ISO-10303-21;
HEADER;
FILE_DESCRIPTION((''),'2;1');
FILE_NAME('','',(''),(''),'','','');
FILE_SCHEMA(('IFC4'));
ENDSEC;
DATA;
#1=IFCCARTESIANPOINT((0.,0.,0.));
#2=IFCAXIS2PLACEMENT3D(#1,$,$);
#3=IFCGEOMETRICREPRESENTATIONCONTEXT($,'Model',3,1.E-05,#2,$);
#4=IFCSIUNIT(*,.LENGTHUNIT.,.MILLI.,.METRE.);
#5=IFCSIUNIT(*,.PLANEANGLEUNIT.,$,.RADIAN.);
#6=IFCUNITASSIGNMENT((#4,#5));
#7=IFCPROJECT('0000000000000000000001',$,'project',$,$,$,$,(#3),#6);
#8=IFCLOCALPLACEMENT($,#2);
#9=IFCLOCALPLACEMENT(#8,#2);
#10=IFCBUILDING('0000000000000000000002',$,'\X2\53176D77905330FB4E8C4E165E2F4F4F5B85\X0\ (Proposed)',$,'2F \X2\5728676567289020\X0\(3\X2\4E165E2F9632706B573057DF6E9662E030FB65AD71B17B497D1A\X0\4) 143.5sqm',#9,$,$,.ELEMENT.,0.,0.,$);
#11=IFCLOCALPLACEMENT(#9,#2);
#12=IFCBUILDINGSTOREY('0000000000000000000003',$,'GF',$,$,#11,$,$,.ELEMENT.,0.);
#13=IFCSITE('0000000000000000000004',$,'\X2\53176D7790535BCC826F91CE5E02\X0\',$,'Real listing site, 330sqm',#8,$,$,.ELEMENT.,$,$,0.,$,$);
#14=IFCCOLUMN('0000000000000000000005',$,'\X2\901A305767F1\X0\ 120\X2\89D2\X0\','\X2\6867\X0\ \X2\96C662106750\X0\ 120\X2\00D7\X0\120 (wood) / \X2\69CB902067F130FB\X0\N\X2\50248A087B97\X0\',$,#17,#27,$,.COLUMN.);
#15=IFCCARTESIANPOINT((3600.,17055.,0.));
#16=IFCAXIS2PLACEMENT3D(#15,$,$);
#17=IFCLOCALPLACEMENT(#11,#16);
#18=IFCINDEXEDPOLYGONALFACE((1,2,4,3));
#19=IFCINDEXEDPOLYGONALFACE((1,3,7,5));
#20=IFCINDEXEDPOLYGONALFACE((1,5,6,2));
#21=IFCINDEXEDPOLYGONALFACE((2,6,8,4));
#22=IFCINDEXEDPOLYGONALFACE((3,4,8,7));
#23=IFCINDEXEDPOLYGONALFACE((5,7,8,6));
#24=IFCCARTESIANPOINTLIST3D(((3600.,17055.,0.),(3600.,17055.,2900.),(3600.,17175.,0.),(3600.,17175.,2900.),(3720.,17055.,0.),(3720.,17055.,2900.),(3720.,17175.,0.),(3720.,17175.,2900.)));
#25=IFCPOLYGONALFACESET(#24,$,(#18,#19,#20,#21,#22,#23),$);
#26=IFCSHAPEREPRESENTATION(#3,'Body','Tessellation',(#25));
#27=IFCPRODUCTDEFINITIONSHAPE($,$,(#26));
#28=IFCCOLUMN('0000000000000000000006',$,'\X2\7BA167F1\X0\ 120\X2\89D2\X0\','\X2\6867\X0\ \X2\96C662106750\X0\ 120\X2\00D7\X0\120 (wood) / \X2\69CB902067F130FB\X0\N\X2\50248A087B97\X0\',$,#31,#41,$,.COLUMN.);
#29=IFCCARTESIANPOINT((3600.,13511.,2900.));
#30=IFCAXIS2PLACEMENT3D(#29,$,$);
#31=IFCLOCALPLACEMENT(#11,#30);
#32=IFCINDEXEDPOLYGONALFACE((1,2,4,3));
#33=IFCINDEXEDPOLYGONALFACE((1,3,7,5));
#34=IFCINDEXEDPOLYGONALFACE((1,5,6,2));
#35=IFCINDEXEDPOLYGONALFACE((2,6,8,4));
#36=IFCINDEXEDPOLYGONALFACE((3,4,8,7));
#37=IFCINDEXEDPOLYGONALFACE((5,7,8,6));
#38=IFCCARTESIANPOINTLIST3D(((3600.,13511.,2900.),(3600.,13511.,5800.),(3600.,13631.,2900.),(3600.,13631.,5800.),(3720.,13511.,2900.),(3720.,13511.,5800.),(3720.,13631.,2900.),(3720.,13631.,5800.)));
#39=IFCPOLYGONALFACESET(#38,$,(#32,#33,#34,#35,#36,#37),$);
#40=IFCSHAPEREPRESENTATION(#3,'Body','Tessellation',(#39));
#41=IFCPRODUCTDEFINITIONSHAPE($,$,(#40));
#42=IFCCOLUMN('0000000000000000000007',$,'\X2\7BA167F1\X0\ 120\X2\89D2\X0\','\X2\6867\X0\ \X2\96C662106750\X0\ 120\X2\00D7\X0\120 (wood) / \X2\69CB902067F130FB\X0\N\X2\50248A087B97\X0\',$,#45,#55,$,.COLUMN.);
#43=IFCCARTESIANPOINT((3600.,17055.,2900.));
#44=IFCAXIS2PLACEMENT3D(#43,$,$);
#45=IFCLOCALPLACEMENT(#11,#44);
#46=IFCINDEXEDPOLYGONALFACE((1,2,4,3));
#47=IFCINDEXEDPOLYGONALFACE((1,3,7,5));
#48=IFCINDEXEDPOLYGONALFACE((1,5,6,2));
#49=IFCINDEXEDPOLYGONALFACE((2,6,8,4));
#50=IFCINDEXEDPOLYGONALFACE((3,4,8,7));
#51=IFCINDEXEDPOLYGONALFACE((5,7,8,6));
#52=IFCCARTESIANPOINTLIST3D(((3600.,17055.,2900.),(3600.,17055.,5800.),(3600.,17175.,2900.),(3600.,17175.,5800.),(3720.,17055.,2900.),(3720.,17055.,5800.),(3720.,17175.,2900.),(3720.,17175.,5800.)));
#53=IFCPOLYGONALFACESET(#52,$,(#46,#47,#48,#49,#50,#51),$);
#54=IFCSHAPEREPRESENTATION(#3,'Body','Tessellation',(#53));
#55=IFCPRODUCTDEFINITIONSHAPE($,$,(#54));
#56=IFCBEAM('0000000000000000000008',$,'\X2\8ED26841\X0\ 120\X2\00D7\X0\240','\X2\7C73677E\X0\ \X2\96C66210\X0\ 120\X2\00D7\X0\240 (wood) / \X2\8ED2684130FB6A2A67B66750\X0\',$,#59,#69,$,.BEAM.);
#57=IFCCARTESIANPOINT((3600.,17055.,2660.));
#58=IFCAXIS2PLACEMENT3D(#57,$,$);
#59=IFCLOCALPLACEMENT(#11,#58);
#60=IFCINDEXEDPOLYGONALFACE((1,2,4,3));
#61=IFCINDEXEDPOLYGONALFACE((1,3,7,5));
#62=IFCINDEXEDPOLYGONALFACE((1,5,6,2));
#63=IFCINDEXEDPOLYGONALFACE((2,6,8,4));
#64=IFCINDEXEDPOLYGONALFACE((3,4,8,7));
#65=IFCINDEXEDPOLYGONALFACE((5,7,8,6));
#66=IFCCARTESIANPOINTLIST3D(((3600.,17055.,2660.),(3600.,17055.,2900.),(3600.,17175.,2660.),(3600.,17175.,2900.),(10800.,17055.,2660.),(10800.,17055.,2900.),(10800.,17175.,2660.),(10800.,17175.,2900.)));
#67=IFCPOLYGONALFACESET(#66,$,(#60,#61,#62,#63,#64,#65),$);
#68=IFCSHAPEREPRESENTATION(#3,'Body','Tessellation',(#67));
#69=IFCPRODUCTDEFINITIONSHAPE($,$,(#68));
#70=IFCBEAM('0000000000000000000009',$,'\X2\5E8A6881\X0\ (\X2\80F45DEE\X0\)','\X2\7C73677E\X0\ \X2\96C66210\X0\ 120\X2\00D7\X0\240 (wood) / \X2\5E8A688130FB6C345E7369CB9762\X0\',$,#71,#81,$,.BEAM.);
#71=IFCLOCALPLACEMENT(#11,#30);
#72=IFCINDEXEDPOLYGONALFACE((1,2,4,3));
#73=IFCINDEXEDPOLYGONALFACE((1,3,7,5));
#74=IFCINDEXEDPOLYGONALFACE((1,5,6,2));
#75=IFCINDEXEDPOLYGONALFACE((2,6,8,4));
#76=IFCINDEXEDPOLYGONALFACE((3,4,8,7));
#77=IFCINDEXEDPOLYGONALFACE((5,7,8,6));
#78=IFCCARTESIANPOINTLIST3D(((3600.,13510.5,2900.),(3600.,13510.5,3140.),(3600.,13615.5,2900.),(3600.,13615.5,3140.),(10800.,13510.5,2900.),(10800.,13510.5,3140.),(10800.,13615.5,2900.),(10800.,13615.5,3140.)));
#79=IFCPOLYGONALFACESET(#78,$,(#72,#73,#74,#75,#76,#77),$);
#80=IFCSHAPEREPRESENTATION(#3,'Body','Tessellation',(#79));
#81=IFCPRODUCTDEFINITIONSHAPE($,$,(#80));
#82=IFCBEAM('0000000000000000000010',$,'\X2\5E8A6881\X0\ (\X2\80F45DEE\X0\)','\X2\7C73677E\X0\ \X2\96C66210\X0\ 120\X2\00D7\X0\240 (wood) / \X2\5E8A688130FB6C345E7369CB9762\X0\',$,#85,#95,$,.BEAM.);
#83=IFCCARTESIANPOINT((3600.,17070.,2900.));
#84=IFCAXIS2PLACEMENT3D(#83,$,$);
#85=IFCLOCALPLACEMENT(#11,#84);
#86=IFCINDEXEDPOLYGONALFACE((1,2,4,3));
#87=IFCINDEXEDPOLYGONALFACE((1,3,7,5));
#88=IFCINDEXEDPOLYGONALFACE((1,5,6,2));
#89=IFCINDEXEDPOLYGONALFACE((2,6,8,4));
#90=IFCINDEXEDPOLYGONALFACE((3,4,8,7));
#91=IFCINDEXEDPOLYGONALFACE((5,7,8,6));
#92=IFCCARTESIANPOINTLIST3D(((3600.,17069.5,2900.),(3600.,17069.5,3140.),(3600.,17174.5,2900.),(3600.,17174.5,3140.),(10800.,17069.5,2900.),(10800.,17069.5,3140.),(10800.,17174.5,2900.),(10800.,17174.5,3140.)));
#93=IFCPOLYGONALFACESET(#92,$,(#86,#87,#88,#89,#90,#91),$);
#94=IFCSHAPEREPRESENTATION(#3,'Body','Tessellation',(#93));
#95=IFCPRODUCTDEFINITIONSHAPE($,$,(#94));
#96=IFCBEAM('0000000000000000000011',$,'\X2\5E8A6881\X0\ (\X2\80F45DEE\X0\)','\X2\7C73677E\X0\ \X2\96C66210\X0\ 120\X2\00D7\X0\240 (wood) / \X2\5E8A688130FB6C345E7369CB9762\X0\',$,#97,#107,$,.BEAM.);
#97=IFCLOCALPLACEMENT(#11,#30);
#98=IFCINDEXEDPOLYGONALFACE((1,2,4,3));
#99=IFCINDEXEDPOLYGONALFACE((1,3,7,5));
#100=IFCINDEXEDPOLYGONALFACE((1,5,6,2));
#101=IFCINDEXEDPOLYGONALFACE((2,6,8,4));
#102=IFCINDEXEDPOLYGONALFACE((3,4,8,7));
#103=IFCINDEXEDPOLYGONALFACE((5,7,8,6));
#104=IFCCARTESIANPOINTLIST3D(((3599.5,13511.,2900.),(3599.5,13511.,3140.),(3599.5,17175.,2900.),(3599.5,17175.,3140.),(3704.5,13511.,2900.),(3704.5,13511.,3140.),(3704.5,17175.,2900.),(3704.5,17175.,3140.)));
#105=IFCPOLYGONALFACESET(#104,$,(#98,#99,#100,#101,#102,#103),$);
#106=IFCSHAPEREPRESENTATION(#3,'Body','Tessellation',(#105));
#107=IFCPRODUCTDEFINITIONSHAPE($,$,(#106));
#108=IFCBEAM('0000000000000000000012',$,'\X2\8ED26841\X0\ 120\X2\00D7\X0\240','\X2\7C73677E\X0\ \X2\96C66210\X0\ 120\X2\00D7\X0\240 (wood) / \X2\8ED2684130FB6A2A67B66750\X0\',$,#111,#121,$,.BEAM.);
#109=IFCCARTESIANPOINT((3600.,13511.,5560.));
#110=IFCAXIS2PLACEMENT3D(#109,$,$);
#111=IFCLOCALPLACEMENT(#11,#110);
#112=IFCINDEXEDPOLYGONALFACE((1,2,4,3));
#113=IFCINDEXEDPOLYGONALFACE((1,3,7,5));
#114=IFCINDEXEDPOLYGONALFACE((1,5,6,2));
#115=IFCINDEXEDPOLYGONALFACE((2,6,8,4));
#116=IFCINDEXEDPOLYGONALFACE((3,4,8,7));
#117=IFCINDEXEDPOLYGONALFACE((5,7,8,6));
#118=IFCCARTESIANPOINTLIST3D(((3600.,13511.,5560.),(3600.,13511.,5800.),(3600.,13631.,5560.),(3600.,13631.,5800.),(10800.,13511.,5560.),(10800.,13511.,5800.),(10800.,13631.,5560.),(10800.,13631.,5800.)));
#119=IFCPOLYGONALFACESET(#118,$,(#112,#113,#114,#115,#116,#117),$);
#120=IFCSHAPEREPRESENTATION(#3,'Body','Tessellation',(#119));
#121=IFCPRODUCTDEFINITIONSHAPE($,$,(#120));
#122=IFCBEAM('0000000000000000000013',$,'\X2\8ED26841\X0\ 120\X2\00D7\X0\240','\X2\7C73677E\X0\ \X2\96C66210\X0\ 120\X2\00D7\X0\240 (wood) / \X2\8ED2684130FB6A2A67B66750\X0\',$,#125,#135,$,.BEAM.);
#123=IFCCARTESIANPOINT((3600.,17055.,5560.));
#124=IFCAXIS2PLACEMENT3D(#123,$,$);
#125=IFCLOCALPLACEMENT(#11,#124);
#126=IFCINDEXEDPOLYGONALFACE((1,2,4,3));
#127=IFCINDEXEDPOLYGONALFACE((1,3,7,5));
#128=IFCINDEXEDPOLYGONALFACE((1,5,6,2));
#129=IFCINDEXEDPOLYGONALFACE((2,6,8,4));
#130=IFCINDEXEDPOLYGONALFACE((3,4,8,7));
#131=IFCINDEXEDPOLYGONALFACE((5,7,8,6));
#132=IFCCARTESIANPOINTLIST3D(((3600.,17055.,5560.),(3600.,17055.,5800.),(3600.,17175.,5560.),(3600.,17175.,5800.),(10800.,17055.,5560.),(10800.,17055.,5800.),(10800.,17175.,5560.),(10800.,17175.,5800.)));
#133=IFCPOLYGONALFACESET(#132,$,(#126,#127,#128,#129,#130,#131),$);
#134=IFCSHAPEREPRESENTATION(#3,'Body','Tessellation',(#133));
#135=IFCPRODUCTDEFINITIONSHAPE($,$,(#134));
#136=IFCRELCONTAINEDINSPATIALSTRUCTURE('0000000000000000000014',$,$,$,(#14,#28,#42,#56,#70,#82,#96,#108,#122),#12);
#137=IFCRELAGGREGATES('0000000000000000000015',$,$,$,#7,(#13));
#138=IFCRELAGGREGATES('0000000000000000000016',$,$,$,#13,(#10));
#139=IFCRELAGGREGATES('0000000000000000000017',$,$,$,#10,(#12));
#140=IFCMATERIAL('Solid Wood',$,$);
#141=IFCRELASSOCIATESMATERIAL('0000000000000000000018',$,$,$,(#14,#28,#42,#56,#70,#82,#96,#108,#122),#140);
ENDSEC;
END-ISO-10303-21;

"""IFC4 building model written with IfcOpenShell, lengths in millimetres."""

from ifc_helpers import new_model, si_unit, frame, frame_2d, origin, place, context, project, spatial, rectangle, extrude, material, element, save


model = new_model("IFC4")

# Units and contexts
model_context = context("Model", 3, precision=1e-05, world=origin())
ifc_project = project(units=[si_unit("LENGTHUNIT", "METRE", prefix="MILLI"), si_unit("PLANEANGLEUNIT", "RADIAN")], contexts=[model_context])

# Site, building, storey
site_placement = place(None, origin())
site = spatial("IfcSite", under=ifc_project, at=site_placement, Name="北海道富良野市", ObjectType="Real listing site, 330sqm", CompositionType="ELEMENT", RefElevation=0.0)
building_placement = place(site_placement, origin())
building = spatial("IfcBuilding", under=site, at=building_placement, Name="北海道・二世帯住宅 (Proposed)", ObjectType="2F 在来木造(3世帯防火地域準拠・断熱等級4) 143.5sqm", CompositionType="ELEMENT", ElevationOfRefHeight=0.0, ElevationOfTerrain=0.0)
storey_placement = place(building_placement, origin())
storey = spatial("IfcBuildingStorey", under=building, at=storey_placement, Name="GF", CompositionType="ELEMENT", Elevation=0.0)

# Columns
ifc_material_1 = material(Name="Solid Wood")
column_1_placement = place(storey_placement, frame((3600.0, 17055.0, 0.0)))
element("IfcColumn", 1, at=column_1_placement, inside=storey, material=ifc_material_1, Name="通し柱 120角", Description="桧 集成材 120×120 (wood) / 構造柱・N値計算", PredefinedType="COLUMN", context=model_context, shape_type="SweptSolid", body=[
    extrude(rectangle(XDim=120.0, YDim=120.0, at=frame_2d((60.0, 60.0))), frame((3600.0, 17055.0, 0.0)), (0.0, 0.0, 1.0), 2900.0),
])
column_2_placement = place(storey_placement, frame((3600.0, 13511.0, 2900.0)))
element("IfcColumn", 2, at=column_2_placement, inside=storey, material=ifc_material_1, Name="管柱 120角", Description="桧 集成材 120×120 (wood) / 構造柱・N値計算", PredefinedType="COLUMN", context=model_context, shape_type="SweptSolid", body=[
    extrude(rectangle(XDim=120.0, YDim=120.0, at=frame_2d((60.0, 60.0))), frame((3600.0, 13511.0, 2900.0)), (0.0, 0.0, 1.0), 2900.0),
])
column_3_placement = place(storey_placement, frame((3600.0, 17055.0, 2900.0)))
element("IfcColumn", 3, at=column_3_placement, inside=storey, material=ifc_material_1, Name="管柱 120角", Description="桧 集成材 120×120 (wood) / 構造柱・N値計算", PredefinedType="COLUMN", context=model_context, shape_type="SweptSolid", body=[
    extrude(rectangle(XDim=120.0, YDim=120.0, at=frame_2d((60.0, 60.0))), frame((3600.0, 17055.0, 2900.0)), (0.0, 0.0, 1.0), 2900.0),
])

# Beams
beam_1_placement = place(storey_placement, frame((3600.0, 17055.0, 2660.0)))
element("IfcBeam", 4, at=beam_1_placement, inside=storey, material=ifc_material_1, Name="軒桁 120×240", Description="米松 集成 120×240 (wood) / 軒桁・横架材", PredefinedType="BEAM", context=model_context, shape_type="SweptSolid", body=[
    extrude(rectangle(XDim=7200.0, YDim=120.0, at=frame_2d((3600.0, 60.0))), frame((3600.0, 17055.0, 2660.0)), (0.0, 0.0, 1.0), 240.0),
])
beam_2_placement = place(storey_placement, frame((3600.0, 13511.0, 2900.0)))
element("IfcBeam", 5, at=beam_2_placement, inside=storey, material=ifc_material_1, Name="床梁 (胴差)", Description="米松 集成 120×240 (wood) / 床梁・水平構面", PredefinedType="BEAM", context=model_context, shape_type="SweptSolid", body=[
    extrude(rectangle(XDim=7200.0, YDim=105.0, at=frame_2d((3600.0, 52.0))), frame((3600.0, 13511.0, 2900.0)), (0.0, 0.0, 1.0), 240.0),
])
beam_3_placement = place(storey_placement, frame((3600.0, 17070.0, 2900.0)))
element("IfcBeam", 6, at=beam_3_placement, inside=storey, material=ifc_material_1, Name="床梁 (胴差)", Description="米松 集成 120×240 (wood) / 床梁・水平構面", PredefinedType="BEAM", context=model_context, shape_type="SweptSolid", body=[
    extrude(rectangle(XDim=7200.0, YDim=105.0, at=frame_2d((3600.0, 52.0))), frame((3600.0, 17070.0, 2900.0)), (0.0, 0.0, 1.0), 240.0),
])
beam_4_placement = place(storey_placement, frame((3600.0, 13511.0, 2900.0)))
element("IfcBeam", 7, at=beam_4_placement, inside=storey, material=ifc_material_1, Name="床梁 (胴差)", Description="米松 集成 120×240 (wood) / 床梁・水平構面", PredefinedType="BEAM", context=model_context, shape_type="SweptSolid", body=[
    extrude(rectangle(XDim=105.0, YDim=3664.0, at=frame_2d((52.0, 1832.0))), frame((3600.0, 13511.0, 2900.0)), (0.0, 0.0, 1.0), 240.0),
])
beam_5_placement = place(storey_placement, frame((3600.0, 13511.0, 5560.0)))
element("IfcBeam", 8, at=beam_5_placement, inside=storey, material=ifc_material_1, Name="軒桁 120×240", Description="米松 集成 120×240 (wood) / 軒桁・横架材", PredefinedType="BEAM", context=model_context, shape_type="SweptSolid", body=[
    extrude(rectangle(XDim=7200.0, YDim=120.0, at=frame_2d((3600.0, 60.0))), frame((3600.0, 13511.0, 5560.0)), (0.0, 0.0, 1.0), 240.0),
])
beam_6_placement = place(storey_placement, frame((3600.0, 17055.0, 5560.0)))
element("IfcBeam", 9, at=beam_6_placement, inside=storey, material=ifc_material_1, Name="軒桁 120×240", Description="米松 集成 120×240 (wood) / 軒桁・横架材", PredefinedType="BEAM", context=model_context, shape_type="SweptSolid", body=[
    extrude(rectangle(XDim=7200.0, YDim=120.0, at=frame_2d((3600.0, 60.0))), frame((3600.0, 17055.0, 5560.0)), (0.0, 0.0, 1.0), 240.0),
])

save(model, "model.ifc")
